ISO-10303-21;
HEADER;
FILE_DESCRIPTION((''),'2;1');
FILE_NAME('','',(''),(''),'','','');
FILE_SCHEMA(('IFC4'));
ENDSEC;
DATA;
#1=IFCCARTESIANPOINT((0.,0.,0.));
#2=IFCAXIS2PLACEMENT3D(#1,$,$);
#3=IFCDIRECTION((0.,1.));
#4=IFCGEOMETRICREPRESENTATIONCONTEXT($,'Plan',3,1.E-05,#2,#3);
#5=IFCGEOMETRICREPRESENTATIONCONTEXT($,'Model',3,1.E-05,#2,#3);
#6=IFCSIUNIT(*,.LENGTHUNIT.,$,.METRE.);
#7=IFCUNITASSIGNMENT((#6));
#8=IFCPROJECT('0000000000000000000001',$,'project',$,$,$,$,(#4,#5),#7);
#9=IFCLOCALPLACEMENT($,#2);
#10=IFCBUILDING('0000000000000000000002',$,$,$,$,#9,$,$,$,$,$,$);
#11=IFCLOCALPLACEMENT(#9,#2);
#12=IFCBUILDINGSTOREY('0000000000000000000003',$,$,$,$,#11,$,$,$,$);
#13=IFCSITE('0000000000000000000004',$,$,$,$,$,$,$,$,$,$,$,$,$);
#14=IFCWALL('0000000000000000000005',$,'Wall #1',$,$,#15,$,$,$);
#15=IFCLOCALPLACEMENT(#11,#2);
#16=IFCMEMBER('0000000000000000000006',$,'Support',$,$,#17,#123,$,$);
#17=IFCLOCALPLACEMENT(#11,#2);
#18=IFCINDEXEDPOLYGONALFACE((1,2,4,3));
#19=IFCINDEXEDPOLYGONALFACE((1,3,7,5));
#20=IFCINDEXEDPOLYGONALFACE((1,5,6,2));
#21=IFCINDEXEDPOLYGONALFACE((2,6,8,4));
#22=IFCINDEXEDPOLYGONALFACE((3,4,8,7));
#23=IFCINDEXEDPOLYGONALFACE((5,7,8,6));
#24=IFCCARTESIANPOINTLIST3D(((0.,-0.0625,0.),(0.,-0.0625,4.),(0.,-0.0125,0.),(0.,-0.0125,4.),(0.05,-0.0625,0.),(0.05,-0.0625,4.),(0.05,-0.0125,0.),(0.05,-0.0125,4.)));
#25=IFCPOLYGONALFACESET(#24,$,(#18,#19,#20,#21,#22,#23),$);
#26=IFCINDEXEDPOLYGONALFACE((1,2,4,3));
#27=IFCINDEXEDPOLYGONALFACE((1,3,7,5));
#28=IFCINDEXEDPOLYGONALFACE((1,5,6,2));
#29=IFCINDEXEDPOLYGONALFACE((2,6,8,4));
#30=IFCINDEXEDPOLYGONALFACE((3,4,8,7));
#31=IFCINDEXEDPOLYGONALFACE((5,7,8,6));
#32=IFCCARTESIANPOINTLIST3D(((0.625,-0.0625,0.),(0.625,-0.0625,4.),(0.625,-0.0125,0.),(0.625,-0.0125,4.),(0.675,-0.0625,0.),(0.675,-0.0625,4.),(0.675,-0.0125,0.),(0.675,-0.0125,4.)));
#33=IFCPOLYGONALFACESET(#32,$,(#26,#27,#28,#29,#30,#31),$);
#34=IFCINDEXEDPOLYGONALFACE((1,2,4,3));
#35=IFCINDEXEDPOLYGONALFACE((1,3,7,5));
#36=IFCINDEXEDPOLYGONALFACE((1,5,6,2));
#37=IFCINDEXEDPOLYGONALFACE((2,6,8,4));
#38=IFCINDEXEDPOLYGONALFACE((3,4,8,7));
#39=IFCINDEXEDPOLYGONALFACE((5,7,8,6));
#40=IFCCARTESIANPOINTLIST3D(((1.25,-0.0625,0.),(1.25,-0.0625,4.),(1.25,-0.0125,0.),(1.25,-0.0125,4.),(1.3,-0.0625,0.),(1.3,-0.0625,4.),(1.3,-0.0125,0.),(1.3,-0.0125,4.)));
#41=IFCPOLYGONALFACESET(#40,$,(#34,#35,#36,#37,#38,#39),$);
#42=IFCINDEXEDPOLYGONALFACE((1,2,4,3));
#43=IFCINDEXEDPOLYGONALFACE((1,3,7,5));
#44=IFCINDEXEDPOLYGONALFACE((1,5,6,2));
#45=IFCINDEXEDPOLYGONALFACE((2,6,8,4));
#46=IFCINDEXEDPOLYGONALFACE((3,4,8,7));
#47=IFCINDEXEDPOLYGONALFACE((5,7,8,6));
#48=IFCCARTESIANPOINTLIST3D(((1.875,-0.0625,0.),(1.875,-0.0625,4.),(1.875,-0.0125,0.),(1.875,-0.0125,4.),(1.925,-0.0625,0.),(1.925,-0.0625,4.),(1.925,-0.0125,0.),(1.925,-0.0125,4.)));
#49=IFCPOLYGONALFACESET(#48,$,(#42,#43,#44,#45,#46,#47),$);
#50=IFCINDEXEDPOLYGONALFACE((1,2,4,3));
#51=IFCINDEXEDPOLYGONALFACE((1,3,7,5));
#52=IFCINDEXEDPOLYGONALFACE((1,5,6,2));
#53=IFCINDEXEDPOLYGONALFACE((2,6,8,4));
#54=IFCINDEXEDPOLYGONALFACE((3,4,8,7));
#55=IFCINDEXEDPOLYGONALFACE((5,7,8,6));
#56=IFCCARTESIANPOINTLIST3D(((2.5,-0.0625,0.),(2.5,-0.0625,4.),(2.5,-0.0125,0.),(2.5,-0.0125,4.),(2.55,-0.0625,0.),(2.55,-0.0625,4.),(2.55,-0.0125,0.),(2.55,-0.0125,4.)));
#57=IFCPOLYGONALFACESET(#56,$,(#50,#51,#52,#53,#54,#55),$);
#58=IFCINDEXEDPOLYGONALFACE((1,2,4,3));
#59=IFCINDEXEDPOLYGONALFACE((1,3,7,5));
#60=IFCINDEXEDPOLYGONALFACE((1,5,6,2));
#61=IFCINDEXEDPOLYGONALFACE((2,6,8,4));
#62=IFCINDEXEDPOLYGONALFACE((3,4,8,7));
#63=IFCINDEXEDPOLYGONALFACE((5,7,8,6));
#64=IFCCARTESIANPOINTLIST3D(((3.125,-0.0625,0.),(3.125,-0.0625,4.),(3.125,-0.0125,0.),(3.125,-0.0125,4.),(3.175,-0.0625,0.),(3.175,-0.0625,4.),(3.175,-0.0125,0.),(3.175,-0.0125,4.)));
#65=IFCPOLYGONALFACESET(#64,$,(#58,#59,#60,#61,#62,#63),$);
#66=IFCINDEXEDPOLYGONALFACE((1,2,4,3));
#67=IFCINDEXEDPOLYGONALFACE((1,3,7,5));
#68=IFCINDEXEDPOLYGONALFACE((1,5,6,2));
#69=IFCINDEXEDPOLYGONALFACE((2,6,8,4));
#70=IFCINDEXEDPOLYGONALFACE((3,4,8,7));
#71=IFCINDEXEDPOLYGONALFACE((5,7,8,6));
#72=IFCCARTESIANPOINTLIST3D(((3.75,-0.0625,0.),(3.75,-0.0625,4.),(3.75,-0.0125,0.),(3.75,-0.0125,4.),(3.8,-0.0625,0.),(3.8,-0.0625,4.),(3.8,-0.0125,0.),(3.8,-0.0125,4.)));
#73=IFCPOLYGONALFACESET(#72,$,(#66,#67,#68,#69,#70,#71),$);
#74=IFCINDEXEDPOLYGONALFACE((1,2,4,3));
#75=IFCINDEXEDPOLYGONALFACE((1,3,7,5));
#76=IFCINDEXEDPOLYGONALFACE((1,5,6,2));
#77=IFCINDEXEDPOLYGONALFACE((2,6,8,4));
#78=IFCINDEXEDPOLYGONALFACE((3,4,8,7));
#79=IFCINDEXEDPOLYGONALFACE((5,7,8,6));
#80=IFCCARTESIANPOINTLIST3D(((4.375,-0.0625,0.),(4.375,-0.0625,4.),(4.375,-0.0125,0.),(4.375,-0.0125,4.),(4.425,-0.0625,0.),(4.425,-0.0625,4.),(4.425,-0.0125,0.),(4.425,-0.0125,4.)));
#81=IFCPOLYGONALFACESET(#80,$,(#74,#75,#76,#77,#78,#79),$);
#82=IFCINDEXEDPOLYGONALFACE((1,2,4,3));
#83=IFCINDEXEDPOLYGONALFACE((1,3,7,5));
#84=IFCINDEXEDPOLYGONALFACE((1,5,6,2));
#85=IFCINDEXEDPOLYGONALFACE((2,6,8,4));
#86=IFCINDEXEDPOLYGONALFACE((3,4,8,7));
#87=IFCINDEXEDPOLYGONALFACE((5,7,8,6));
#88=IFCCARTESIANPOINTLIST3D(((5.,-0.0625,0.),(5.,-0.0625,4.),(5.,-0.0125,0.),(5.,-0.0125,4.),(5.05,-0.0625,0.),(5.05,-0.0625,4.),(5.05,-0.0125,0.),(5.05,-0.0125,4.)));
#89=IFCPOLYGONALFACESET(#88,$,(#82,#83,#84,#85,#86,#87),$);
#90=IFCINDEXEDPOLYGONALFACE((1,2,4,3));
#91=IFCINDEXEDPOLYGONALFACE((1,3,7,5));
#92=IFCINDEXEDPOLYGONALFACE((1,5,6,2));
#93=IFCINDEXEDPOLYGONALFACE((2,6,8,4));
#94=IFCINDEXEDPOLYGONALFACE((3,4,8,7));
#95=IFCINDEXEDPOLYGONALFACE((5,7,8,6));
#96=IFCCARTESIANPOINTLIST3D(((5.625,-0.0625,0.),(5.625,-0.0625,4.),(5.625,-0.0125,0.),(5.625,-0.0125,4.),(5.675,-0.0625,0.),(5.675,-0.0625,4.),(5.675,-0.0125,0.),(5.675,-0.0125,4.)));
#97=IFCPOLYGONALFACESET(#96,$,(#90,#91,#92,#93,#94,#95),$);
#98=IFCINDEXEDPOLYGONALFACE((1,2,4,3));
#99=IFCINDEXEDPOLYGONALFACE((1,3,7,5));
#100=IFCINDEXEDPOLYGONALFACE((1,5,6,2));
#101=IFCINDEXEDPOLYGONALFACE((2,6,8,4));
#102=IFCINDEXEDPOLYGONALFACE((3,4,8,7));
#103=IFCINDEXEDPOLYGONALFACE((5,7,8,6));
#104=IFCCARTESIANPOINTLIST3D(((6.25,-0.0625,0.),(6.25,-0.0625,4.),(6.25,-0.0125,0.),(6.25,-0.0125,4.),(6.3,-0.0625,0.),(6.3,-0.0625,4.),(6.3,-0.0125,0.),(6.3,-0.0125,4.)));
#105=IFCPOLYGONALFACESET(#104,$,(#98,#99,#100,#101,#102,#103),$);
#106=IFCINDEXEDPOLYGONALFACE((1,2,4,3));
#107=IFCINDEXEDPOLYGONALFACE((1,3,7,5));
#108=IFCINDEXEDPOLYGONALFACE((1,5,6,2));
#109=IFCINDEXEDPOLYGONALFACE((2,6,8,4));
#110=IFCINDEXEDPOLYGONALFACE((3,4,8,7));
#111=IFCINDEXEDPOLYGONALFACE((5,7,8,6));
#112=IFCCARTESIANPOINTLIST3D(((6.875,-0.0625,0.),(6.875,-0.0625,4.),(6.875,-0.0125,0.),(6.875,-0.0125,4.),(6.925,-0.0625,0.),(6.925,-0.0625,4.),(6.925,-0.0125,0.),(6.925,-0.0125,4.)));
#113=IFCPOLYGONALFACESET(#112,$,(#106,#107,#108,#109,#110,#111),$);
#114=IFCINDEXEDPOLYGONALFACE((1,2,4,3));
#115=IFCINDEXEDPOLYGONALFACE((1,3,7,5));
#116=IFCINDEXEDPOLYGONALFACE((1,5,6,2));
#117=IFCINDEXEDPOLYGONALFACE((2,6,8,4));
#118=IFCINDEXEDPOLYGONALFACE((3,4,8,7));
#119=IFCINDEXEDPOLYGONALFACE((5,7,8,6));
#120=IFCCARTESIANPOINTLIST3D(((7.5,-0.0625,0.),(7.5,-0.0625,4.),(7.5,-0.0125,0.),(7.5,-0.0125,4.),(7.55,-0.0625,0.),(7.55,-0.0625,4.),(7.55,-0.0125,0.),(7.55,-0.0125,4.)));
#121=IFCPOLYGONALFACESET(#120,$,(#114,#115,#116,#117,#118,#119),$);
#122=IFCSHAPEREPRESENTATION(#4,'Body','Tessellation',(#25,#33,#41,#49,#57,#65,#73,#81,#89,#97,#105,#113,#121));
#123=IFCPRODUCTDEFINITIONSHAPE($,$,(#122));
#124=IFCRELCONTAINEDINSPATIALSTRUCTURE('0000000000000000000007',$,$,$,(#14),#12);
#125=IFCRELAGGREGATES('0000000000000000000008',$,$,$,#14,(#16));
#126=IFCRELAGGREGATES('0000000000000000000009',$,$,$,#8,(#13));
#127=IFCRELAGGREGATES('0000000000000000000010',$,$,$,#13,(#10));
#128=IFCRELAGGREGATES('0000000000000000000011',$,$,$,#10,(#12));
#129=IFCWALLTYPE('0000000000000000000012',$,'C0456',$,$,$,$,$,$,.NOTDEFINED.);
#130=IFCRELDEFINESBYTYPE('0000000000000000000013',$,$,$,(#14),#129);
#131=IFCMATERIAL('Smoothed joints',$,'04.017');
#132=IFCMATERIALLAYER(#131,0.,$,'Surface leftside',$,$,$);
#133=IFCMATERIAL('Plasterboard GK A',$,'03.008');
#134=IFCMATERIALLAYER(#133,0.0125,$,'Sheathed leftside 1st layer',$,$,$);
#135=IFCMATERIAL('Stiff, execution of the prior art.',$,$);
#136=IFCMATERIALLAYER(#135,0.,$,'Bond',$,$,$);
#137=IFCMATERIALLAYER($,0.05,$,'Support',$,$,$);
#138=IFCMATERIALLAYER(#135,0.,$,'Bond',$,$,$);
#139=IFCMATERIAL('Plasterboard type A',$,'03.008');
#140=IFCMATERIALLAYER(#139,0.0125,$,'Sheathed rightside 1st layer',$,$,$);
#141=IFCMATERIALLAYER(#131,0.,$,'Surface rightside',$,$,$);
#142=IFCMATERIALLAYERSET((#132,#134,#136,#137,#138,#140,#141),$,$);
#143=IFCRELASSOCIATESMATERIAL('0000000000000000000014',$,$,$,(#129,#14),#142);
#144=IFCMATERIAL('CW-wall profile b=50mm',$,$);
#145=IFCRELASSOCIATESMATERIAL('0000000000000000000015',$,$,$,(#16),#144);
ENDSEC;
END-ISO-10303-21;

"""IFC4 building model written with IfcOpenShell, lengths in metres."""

from ifc_helpers import new_model, si_unit, direction, frame, frame_2d, origin, place, context, project, spatial, rectangle, extrude, material, layer, layer_set, type_object, element, aggregate, save


model = new_model("IFC4")

# Units and contexts
plan_context = context("Plan", 3, precision=1e-05, world=origin(), true_north=direction((0.0, 1.0)))
model_context = context("Model", 3, precision=1e-05, world=origin(), true_north=direction((0.0, 1.0)))
ifc_project = project(units=[si_unit("LENGTHUNIT", "METRE")], contexts=[plan_context, model_context])

# Site, building, storey
site = spatial("IfcSite", under=ifc_project)
building_placement = place(None, origin())
building = spatial("IfcBuilding", under=site, at=building_placement)
storey_placement = place(building_placement, origin())
storey = spatial("IfcBuildingStorey", under=building, at=storey_placement)

# Wall, member
ifc_material_1 = material(Name="Smoothed joints", Category="04.017")
ifc_layer_1 = layer(ifc_material_1, 0.0, Name="Surface leftside")
ifc_material_2 = material(Name="Plasterboard GK A", Category="03.008")
ifc_layer_2 = layer(ifc_material_2, 0.0125, Name="Sheathed leftside 1st layer")
ifc_material_3 = material(Name="Stiff, execution of the prior art.")
ifc_layer_3 = layer(ifc_material_3, 0.0, Name="Bond")
ifc_layer_4 = layer(None, 0.05, Name="Support")
ifc_layer_5 = layer(ifc_material_3, 0.0, Name="Bond")
ifc_material_4 = material(Name="Plasterboard type A", Category="03.008")
ifc_layer_6 = layer(ifc_material_4, 0.0125, Name="Sheathed rightside 1st layer")
ifc_layer_7 = layer(ifc_material_1, 0.0, Name="Surface rightside")
ifc_layer_set = layer_set([ifc_layer_1, ifc_layer_2, ifc_layer_3, ifc_layer_4, ifc_layer_5, ifc_layer_6, ifc_layer_7])
wall_type = type_object("IfcWallType", Name="C0456", PredefinedType="NOTDEFINED", material=ifc_layer_set)
wall_placement = place(None, frame((0.0, 0.0, 0.0), z_axis=(0.0, -1.0, 0.0), x_axis=(1.0, 0.0, 0.0)))
wall = element("IfcWall", 1, at=wall_placement, inside=storey, type_object=wall_type, material=ifc_layer_set, Name="Wall #1")
ifc_material_5 = material(Name="CW-wall profile b=50mm")
member_1_placement = place(wall_placement, origin())
member_1 = element("IfcMember", 2, at=member_1_placement, material=ifc_material_5, Name="Support", context=plan_context, shape_type="SweptSolid", body=[
    extrude(rectangle(XDim=0.05, YDim=0.05, at=frame_2d((0.025, 0.025), x_axis=(1.0, 0.0))), frame((0.0, 4.0, 0.0125), z_axis=(0.0, -1.0, 0.0), x_axis=(1.0, 0.0, 0.0)), (0.0, 0.0, 1.0), 4.0),
    extrude(rectangle(XDim=0.05, YDim=0.05, at=frame_2d((0.025, 0.025), x_axis=(1.0, 0.0))), frame((0.625, 4.0, 0.0125), z_axis=(0.0, -1.0, 0.0), x_axis=(1.0, 0.0, 0.0)), (0.0, 0.0, 1.0), 4.0),
    extrude(rectangle(XDim=0.05, YDim=0.05, at=frame_2d((0.025, 0.025), x_axis=(1.0, 0.0))), frame((1.25, 4.0, 0.0125), z_axis=(0.0, -1.0, 0.0), x_axis=(1.0, 0.0, 0.0)), (0.0, 0.0, 1.0), 4.0),
    extrude(rectangle(XDim=0.05, YDim=0.05, at=frame_2d((0.025, 0.025), x_axis=(1.0, 0.0))), frame((1.875, 4.0, 0.0125), z_axis=(0.0, -1.0, 0.0), x_axis=(1.0, 0.0, 0.0)), (0.0, 0.0, 1.0), 4.0),
    extrude(rectangle(XDim=0.05, YDim=0.05, at=frame_2d((0.025, 0.025), x_axis=(1.0, 0.0))), frame((2.5, 4.0, 0.0125), z_axis=(0.0, -1.0, 0.0), x_axis=(1.0, 0.0, 0.0)), (0.0, 0.0, 1.0), 4.0),
    extrude(rectangle(XDim=0.05, YDim=0.05, at=frame_2d((0.025, 0.025), x_axis=(1.0, 0.0))), frame((3.125, 4.0, 0.0125), z_axis=(0.0, -1.0, 0.0), x_axis=(1.0, 0.0, 0.0)), (0.0, 0.0, 1.0), 4.0),
    extrude(rectangle(XDim=0.05, YDim=0.05, at=frame_2d((0.025, 0.025), x_axis=(1.0, 0.0))), frame((3.75, 4.0, 0.0125), z_axis=(0.0, -1.0, 0.0), x_axis=(1.0, 0.0, 0.0)), (0.0, 0.0, 1.0), 4.0),
    extrude(rectangle(XDim=0.05, YDim=0.05, at=frame_2d((0.025, 0.025), x_axis=(1.0, 0.0))), frame((4.375, 4.0, 0.0125), z_axis=(0.0, -1.0, 0.0), x_axis=(1.0, 0.0, 0.0)), (0.0, 0.0, 1.0), 4.0),
    extrude(rectangle(XDim=0.05, YDim=0.05, at=frame_2d((0.025, 0.025), x_axis=(1.0, 0.0))), frame((5.0, 4.0, 0.0125), z_axis=(0.0, -1.0, 0.0), x_axis=(1.0, 0.0, 0.0)), (0.0, 0.0, 1.0), 4.0),
    extrude(rectangle(XDim=0.05, YDim=0.05, at=frame_2d((0.025, 0.025), x_axis=(1.0, 0.0))), frame((5.625, 4.0, 0.0125), z_axis=(0.0, -1.0, 0.0), x_axis=(1.0, 0.0, 0.0)), (0.0, 0.0, 1.0), 4.0),
    extrude(rectangle(XDim=0.05, YDim=0.05, at=frame_2d((0.025, 0.025), x_axis=(1.0, 0.0))), frame((6.25, 4.0, 0.0125), z_axis=(0.0, -1.0, 0.0), x_axis=(1.0, 0.0, 0.0)), (0.0, 0.0, 1.0), 4.0),
    extrude(rectangle(XDim=0.05, YDim=0.05, at=frame_2d((0.025, 0.025), x_axis=(1.0, 0.0))), frame((6.875, 4.0, 0.0125), z_axis=(0.0, -1.0, 0.0), x_axis=(1.0, 0.0, 0.0)), (0.0, 0.0, 1.0), 4.0),
    extrude(rectangle(XDim=0.05, YDim=0.05, at=frame_2d((0.025, 0.025), x_axis=(1.0, 0.0))), frame((7.5, 4.0, 0.0125), z_axis=(0.0, -1.0, 0.0), x_axis=(1.0, 0.0, 0.0)), (0.0, 0.0, 1.0), 4.0),
])
aggregate(wall, [member_1])

save(model, "model.ifc")
